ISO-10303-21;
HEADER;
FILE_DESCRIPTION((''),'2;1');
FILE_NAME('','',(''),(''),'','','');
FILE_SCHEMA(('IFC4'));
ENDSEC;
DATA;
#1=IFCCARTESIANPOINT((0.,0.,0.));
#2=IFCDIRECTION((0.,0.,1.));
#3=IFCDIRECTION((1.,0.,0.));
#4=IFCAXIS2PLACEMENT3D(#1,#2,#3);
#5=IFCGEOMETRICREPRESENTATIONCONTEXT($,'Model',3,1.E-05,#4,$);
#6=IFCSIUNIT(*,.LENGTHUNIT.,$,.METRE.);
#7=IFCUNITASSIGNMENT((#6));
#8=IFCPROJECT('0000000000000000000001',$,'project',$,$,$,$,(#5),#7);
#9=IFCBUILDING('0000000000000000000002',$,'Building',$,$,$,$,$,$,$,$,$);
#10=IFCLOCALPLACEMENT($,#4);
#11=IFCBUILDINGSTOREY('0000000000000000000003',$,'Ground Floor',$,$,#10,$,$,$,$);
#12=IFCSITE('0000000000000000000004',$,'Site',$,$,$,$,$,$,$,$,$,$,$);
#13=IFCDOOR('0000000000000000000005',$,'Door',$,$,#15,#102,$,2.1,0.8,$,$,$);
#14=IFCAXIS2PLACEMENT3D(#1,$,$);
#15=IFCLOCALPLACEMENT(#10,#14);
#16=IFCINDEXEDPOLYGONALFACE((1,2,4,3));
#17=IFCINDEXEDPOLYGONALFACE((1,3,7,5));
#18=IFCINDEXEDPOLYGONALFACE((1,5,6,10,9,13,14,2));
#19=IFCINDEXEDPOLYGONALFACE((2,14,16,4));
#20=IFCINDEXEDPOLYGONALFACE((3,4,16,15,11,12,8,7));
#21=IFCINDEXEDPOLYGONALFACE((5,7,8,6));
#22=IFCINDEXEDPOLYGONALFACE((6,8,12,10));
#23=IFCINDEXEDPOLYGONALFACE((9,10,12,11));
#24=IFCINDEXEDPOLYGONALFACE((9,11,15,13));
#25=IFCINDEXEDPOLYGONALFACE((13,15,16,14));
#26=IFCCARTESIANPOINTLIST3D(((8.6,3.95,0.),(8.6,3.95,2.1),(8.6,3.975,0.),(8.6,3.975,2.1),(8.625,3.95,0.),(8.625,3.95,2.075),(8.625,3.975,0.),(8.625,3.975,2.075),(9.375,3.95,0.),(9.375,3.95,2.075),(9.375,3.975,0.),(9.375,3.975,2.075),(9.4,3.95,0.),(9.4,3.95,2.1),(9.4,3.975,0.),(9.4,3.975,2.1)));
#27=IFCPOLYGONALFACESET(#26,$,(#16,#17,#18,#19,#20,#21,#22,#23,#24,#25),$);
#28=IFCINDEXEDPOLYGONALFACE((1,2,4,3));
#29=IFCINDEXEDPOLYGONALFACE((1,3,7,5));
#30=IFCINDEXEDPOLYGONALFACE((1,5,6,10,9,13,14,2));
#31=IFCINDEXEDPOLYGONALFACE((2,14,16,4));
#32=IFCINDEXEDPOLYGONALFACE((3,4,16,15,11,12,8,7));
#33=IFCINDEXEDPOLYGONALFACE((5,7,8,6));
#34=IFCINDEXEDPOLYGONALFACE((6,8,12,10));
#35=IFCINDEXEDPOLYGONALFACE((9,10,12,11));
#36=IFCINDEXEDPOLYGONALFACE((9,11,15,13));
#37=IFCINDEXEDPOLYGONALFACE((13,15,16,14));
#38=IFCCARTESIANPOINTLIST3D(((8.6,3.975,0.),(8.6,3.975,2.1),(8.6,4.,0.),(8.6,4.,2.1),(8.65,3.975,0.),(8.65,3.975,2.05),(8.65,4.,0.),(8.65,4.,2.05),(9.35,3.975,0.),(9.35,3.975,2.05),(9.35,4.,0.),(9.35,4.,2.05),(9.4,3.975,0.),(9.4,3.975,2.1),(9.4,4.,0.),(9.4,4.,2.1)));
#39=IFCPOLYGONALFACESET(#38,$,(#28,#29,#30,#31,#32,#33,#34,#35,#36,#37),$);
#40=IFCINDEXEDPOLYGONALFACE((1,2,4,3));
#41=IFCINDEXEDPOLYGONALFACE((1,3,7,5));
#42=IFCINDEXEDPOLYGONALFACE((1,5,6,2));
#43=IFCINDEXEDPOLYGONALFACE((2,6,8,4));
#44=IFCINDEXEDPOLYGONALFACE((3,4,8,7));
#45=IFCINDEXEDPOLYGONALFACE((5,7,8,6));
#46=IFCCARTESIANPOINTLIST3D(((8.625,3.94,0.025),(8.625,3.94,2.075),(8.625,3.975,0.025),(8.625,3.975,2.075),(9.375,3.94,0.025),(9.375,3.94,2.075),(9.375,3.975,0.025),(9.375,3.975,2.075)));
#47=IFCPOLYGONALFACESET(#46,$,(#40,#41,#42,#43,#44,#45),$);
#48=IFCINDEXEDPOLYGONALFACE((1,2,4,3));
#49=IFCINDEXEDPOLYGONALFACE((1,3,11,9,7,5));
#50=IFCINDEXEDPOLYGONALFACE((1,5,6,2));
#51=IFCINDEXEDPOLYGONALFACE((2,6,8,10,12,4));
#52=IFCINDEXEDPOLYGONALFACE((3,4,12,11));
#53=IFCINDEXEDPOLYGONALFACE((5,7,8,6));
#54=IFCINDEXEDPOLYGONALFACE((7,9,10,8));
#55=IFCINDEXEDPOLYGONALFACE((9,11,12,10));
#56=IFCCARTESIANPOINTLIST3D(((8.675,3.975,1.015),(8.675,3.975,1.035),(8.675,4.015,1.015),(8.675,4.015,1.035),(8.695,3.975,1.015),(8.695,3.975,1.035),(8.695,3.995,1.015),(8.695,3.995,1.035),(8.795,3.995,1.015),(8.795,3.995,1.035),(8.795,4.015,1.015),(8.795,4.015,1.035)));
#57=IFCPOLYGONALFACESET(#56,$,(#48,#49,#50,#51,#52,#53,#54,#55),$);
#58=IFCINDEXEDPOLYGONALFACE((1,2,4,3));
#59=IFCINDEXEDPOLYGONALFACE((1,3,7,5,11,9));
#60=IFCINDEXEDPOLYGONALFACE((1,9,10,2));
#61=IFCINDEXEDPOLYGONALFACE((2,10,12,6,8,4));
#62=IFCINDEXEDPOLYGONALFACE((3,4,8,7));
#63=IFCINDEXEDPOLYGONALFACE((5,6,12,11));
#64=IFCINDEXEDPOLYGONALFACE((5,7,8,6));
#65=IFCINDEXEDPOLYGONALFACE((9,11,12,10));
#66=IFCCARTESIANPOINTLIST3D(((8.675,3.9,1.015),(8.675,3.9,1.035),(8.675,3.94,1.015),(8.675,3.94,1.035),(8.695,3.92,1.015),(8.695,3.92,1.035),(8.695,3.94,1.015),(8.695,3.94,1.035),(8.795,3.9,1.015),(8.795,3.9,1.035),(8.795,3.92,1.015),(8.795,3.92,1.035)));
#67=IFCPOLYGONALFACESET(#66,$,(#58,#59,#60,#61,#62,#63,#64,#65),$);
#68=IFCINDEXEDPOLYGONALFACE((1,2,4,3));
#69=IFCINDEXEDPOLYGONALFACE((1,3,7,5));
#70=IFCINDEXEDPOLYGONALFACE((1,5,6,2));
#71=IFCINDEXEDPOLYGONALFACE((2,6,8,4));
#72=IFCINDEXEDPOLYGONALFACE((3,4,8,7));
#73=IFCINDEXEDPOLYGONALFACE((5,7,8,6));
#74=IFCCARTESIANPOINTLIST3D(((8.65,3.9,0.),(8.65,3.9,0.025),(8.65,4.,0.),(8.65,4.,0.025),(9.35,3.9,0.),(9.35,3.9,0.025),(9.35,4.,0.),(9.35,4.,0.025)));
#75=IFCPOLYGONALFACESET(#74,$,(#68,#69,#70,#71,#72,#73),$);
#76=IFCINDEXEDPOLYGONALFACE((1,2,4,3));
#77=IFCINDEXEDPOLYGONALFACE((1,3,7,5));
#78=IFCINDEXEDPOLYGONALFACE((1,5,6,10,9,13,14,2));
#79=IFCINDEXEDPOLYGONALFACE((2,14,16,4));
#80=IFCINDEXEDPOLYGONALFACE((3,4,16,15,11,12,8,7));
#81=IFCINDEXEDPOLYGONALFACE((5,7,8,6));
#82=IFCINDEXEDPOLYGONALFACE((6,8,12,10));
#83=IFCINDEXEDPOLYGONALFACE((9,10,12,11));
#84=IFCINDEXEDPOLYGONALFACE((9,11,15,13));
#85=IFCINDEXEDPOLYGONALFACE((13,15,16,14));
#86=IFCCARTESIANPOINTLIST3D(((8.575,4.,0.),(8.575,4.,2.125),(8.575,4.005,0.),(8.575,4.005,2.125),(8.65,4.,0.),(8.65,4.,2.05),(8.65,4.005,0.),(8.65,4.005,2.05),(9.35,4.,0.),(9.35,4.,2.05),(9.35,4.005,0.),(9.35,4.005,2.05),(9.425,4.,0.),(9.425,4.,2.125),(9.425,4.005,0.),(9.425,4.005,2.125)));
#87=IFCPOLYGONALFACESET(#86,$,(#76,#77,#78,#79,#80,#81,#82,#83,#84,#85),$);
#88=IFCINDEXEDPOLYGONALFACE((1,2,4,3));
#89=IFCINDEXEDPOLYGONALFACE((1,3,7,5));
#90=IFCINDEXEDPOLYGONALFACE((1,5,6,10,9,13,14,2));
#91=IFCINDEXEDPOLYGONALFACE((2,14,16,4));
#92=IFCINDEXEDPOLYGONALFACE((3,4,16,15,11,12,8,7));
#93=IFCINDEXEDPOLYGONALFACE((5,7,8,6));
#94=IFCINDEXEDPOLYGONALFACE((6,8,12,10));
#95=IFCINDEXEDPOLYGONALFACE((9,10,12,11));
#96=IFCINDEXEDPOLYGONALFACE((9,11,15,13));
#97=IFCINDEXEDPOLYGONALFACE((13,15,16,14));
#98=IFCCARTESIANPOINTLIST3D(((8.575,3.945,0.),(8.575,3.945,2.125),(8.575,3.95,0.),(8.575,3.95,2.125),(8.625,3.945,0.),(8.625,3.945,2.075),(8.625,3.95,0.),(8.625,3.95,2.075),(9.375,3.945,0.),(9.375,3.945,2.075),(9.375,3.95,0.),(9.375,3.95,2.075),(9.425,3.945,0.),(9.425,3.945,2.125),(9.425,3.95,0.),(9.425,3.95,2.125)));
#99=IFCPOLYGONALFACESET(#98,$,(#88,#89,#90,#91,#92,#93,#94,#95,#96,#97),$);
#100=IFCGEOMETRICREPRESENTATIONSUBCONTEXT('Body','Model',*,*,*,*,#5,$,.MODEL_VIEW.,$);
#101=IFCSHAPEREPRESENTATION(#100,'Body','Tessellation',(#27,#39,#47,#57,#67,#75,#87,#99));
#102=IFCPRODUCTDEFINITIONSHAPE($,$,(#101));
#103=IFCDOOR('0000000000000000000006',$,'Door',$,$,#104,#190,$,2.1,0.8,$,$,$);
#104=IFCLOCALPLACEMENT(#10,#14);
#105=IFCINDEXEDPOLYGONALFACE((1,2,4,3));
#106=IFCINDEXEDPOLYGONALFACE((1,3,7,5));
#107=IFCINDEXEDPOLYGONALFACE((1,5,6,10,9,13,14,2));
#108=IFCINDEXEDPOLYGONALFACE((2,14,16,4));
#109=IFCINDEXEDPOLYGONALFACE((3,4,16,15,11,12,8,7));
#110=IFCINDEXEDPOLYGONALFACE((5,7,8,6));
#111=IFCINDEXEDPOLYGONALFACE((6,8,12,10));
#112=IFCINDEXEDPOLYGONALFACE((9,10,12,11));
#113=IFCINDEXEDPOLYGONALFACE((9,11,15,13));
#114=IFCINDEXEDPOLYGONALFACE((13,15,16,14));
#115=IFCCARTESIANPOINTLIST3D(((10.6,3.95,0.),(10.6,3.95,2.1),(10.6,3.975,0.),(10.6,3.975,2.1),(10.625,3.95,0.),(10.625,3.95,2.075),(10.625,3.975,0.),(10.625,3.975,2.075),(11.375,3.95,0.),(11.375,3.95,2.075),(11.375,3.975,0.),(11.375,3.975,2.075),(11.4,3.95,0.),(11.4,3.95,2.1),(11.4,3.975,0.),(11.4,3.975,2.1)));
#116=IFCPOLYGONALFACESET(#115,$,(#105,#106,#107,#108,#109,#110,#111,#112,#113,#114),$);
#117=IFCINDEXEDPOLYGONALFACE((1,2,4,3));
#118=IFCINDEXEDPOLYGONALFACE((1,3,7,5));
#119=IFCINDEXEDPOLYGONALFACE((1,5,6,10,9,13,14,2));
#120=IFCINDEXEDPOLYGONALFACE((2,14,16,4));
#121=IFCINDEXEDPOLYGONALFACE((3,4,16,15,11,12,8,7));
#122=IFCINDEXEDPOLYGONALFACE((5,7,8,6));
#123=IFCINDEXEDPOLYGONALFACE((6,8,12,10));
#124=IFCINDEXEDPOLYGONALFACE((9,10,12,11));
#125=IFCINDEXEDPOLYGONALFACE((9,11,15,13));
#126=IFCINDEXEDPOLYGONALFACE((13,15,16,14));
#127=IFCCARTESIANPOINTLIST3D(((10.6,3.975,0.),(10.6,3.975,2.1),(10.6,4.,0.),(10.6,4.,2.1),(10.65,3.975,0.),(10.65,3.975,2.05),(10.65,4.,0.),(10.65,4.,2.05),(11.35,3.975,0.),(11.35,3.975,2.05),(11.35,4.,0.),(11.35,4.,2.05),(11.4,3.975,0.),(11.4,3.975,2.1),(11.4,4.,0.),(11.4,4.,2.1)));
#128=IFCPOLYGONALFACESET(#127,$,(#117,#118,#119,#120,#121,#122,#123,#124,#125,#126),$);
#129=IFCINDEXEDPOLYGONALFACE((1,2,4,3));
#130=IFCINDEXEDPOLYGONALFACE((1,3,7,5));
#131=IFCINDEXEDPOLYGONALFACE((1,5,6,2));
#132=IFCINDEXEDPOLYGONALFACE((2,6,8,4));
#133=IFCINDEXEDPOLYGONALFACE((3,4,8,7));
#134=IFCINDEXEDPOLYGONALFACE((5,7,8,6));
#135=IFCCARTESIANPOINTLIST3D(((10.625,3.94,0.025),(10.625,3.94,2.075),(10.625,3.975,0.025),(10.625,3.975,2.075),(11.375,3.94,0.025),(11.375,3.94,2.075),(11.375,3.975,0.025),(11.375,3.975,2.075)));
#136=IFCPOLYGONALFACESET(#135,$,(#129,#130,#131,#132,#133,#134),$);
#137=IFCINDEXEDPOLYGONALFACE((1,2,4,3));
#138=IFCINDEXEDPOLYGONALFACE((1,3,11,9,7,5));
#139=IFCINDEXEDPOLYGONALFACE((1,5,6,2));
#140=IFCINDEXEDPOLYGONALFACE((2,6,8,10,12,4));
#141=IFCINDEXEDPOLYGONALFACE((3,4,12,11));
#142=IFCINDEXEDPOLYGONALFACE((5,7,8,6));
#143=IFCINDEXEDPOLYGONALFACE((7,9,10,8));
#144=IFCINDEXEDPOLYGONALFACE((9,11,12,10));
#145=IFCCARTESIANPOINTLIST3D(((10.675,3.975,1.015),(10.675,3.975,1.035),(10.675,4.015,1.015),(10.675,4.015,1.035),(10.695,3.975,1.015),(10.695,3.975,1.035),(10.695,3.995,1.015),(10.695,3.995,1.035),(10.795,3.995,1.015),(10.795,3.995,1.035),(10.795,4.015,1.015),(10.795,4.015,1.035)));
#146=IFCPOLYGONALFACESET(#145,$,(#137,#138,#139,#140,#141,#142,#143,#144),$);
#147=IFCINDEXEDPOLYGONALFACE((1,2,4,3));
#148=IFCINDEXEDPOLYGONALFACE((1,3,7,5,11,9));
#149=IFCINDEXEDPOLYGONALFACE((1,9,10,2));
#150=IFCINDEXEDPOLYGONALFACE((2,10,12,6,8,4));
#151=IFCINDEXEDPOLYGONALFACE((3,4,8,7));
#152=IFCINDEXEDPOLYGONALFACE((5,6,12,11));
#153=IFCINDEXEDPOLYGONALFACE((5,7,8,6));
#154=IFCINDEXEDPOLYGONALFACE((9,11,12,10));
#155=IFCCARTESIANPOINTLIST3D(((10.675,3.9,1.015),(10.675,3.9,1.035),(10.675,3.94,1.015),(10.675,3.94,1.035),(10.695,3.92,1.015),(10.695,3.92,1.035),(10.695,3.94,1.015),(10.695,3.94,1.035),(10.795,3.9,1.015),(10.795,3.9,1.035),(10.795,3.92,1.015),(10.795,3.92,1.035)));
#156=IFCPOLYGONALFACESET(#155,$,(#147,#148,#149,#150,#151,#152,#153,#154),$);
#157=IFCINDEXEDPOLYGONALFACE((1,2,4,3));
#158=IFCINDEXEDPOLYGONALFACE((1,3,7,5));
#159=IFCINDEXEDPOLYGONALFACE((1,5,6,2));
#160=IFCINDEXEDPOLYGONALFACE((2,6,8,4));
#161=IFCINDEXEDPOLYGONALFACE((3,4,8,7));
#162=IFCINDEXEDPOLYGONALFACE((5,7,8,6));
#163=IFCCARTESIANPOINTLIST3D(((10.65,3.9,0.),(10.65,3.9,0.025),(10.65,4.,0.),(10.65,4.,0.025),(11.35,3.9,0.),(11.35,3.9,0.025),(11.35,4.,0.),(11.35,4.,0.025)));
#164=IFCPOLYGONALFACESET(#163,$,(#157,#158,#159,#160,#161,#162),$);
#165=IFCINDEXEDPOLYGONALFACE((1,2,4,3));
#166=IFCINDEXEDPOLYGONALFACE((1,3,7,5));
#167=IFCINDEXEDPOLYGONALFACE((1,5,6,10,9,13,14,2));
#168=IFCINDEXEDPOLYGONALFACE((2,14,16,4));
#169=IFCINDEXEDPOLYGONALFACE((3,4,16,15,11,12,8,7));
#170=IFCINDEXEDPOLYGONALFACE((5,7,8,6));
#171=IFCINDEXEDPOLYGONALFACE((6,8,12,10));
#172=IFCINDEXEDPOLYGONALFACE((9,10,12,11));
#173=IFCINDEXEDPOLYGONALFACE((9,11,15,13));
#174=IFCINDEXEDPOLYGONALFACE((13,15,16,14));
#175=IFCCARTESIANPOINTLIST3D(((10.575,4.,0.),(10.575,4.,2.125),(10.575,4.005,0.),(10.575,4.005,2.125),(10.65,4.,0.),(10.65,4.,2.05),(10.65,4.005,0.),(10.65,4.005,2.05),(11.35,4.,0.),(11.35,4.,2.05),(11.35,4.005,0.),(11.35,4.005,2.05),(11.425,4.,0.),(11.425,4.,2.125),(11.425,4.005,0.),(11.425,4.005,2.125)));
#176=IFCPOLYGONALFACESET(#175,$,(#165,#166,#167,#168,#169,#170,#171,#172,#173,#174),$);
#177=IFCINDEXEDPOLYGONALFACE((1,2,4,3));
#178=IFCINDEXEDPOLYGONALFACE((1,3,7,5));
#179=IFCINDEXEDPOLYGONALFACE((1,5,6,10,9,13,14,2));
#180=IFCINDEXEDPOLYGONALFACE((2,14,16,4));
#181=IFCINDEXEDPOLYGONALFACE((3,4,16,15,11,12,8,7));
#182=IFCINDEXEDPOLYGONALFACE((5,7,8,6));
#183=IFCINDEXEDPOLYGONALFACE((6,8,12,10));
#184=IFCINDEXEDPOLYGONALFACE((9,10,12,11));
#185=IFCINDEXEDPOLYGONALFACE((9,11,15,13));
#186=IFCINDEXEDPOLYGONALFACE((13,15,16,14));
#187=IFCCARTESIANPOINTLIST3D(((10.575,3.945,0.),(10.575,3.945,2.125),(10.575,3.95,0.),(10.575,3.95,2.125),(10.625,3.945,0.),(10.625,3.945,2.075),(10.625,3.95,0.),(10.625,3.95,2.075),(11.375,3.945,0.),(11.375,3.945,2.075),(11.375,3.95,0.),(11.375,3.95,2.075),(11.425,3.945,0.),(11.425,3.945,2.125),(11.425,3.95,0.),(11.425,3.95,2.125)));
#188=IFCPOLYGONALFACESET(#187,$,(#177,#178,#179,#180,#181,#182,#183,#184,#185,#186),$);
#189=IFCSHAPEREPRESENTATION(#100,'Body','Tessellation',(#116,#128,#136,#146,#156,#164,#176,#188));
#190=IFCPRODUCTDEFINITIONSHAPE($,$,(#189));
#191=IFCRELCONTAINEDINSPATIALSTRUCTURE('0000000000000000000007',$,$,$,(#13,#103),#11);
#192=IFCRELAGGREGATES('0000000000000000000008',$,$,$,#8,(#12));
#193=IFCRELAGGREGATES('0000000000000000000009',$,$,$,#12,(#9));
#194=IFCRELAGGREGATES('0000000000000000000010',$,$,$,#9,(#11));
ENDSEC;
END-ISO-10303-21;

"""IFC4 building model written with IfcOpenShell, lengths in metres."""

from ifc_helpers import new_model, si_unit, frame, origin_with_axes, place, context, subcontext, project, spatial, line, indexed_curve, outline, extrude, element, save


model = new_model("IFC4")

# Units and contexts
model_context = context("Model", 3, precision=1e-05, world=origin_with_axes())
body_context = subcontext(model_context, "Body", "Model", "MODEL_VIEW")
ifc_project = project(units=[si_unit("LENGTHUNIT", "METRE")], contexts=[model_context])

# Site, building, storey
site = spatial("IfcSite", under=ifc_project, Name="Site")
building = spatial("IfcBuilding", under=site, Name="Building")
storey_placement = place(None, origin_with_axes())
storey = spatial("IfcBuildingStorey", under=building, at=storey_placement, Name="Ground Floor")

# Doors
door_1_placement = place(storey_placement, frame((9.4, 4.0, 0.0), z_axis=(0.0, 0.0, 1.0), x_axis=(-1.0, 0.0, 0.0)))
element("IfcDoor", 1, at=door_1_placement, inside=storey, Name="Door", OverallHeight=2.1, OverallWidth=0.8, context=body_context, shape_type="SweptSolid", body=[
    extrude(outline(indexed_curve([(0.0, 0.0), (0.0, 2.1), (0.8, 2.1), (0.8, 0.0), (0.775, 0.0), (0.775, 2.075), (0.025, 2.075), (0.025, 0.0)], segments=[line(1, 2, 3, 4, 5, 6, 7, 8, 1)])), frame((0.0, 0.025, 0.0), z_axis=(0.0, -1.0, 0.0), x_axis=(1.0, 0.0, 0.0)), (0.0, 0.0, -1.0), 0.025),
    extrude(outline(indexed_curve([(0.0, 0.0), (0.0, 2.1), (0.8, 2.1), (0.8, 0.0), (0.75, 0.0), (0.75, 2.05), (0.05, 2.05), (0.05, 0.0)], segments=[line(1, 2, 3, 4, 5, 6, 7, 8, 1)])), frame((0.0, 0.0, 0.0), z_axis=(0.0, -1.0, 0.0), x_axis=(1.0, 0.0, 0.0)), (0.0, 0.0, -1.0), 0.025),
    extrude(outline(indexed_curve([(0.0, 0.0), (0.75, 0.0), (0.75, 0.035), (0.0, 0.035)], segments=[line(1, 2, 3, 4, 1)])), frame((0.025, 0.025, 0.025), z_axis=(0.0, 0.0, 1.0), x_axis=(1.0, 0.0, 0.0)), (0.0, 0.0, 1.0), 2.05),
    extrude(outline(indexed_curve([(0.0, 0.0), (0.0, -0.04), (-0.12, -0.04), (-0.12, -0.02), (-0.02, -0.02), (-0.02, 0.0)], segments=[line(1, 2, 3, 4, 5, 6, 1)])), frame((0.725, 0.025, 1.015), z_axis=(0.0, 0.0, 1.0), x_axis=(1.0, 0.0, 0.0)), (0.0, 0.0, 1.0), 0.02),
    extrude(outline(indexed_curve([(0.0, 0.0), (0.0, 0.04), (-0.12, 0.04), (-0.12, 0.02), (-0.02, 0.02), (-0.02, 0.0)], segments=[line(1, 2, 3, 4, 5, 6, 1)])), frame((0.725, 0.06, 1.015), z_axis=(0.0, 0.0, 1.0), x_axis=(1.0, 0.0, 0.0)), (0.0, 0.0, 1.0), 0.02),
    extrude(outline(indexed_curve([(0.0, 0.0), (0.7, 0.0), (0.7, 0.1), (0.0, 0.1)], segments=[line(1, 2, 3, 4, 1)])), frame((0.05, 0.0, 0.0), z_axis=(0.0, 0.0, 1.0), x_axis=(1.0, 0.0, 0.0)), (0.0, 0.0, 1.0), 0.025),
    extrude(outline(indexed_curve([(0.0, 0.0), (0.0, 2.125), (0.85, 2.125), (0.85, 0.0), (0.775, 0.0), (0.775, 2.05), (0.075, 2.05), (0.075, 0.0)], segments=[line(1, 2, 3, 4, 5, 6, 7, 8, 1)])), frame((-0.025, -0.005, 0.0), z_axis=(0.0, -1.0, 0.0), x_axis=(1.0, 0.0, 0.0)), (0.0, 0.0, -1.0), 0.005),
    extrude(outline(indexed_curve([(0.0, 0.0), (0.0, 2.125), (0.85, 2.125), (0.85, 0.0), (0.8, 0.0), (0.8, 2.075), (0.05, 2.075), (0.05, 0.0)], segments=[line(1, 2, 3, 4, 5, 6, 7, 8, 1)])), frame((-0.025, 0.05, 0.0), z_axis=(0.0, -1.0, 0.0), x_axis=(1.0, 0.0, 0.0)), (0.0, 0.0, -1.0), 0.005),
])
door_2_placement = place(storey_placement, frame((11.4, 4.0, 0.0), z_axis=(0.0, 0.0, 1.0), x_axis=(-1.0, 0.0, 0.0)))
element("IfcDoor", 2, at=door_2_placement, inside=storey, Name="Door", OverallHeight=2.1, OverallWidth=0.8, context=body_context, shape_type="SweptSolid", body=[
    extrude(outline(indexed_curve([(0.0, 0.0), (0.0, 2.1), (0.8, 2.1), (0.8, 0.0), (0.775, 0.0), (0.775, 2.075), (0.025, 2.075), (0.025, 0.0)], segments=[line(1, 2, 3, 4, 5, 6, 7, 8, 1)])), frame((0.0, 0.025, 0.0), z_axis=(0.0, -1.0, 0.0), x_axis=(1.0, 0.0, 0.0)), (0.0, 0.0, -1.0), 0.025),
    extrude(outline(indexed_curve([(0.0, 0.0), (0.0, 2.1), (0.8, 2.1), (0.8, 0.0), (0.75, 0.0), (0.75, 2.05), (0.05, 2.05), (0.05, 0.0)], segments=[line(1, 2, 3, 4, 5, 6, 7, 8, 1)])), frame((0.0, 0.0, 0.0), z_axis=(0.0, -1.0, 0.0), x_axis=(1.0, 0.0, 0.0)), (0.0, 0.0, -1.0), 0.025),
    extrude(outline(indexed_curve([(0.0, 0.0), (0.75, 0.0), (0.75, 0.035), (0.0, 0.035)], segments=[line(1, 2, 3, 4, 1)])), frame((0.025, 0.025, 0.025), z_axis=(0.0, 0.0, 1.0), x_axis=(1.0, 0.0, 0.0)), (0.0, 0.0, 1.0), 2.05),
    extrude(outline(indexed_curve([(0.0, 0.0), (0.0, -0.04), (-0.12, -0.04), (-0.12, -0.02), (-0.02, -0.02), (-0.02, 0.0)], segments=[line(1, 2, 3, 4, 5, 6, 1)])), frame((0.725, 0.025, 1.015), z_axis=(0.0, 0.0, 1.0), x_axis=(1.0, 0.0, 0.0)), (0.0, 0.0, 1.0), 0.02),
    extrude(outline(indexed_curve([(0.0, 0.0), (0.0, 0.04), (-0.12, 0.04), (-0.12, 0.02), (-0.02, 0.02), (-0.02, 0.0)], segments=[line(1, 2, 3, 4, 5, 6, 1)])), frame((0.725, 0.06, 1.015), z_axis=(0.0, 0.0, 1.0), x_axis=(1.0, 0.0, 0.0)), (0.0, 0.0, 1.0), 0.02),
    extrude(outline(indexed_curve([(0.0, 0.0), (0.7, 0.0), (0.7, 0.1), (0.0, 0.1)], segments=[line(1, 2, 3, 4, 1)])), frame((0.05, 0.0, 0.0), z_axis=(0.0, 0.0, 1.0), x_axis=(1.0, 0.0, 0.0)), (0.0, 0.0, 1.0), 0.025),
    extrude(outline(indexed_curve([(0.0, 0.0), (0.0, 2.125), (0.85, 2.125), (0.85, 0.0), (0.775, 0.0), (0.775, 2.05), (0.075, 2.05), (0.075, 0.0)], segments=[line(1, 2, 3, 4, 5, 6, 7, 8, 1)])), frame((-0.025, -0.005, 0.0), z_axis=(0.0, -1.0, 0.0), x_axis=(1.0, 0.0, 0.0)), (0.0, 0.0, -1.0), 0.005),
    extrude(outline(indexed_curve([(0.0, 0.0), (0.0, 2.125), (0.85, 2.125), (0.85, 0.0), (0.8, 0.0), (0.8, 2.075), (0.05, 2.075), (0.05, 0.0)], segments=[line(1, 2, 3, 4, 5, 6, 7, 8, 1)])), frame((-0.025, 0.05, 0.0), z_axis=(0.0, -1.0, 0.0), x_axis=(1.0, 0.0, 0.0)), (0.0, 0.0, -1.0), 0.005),
])

save(model, "model.ifc")
